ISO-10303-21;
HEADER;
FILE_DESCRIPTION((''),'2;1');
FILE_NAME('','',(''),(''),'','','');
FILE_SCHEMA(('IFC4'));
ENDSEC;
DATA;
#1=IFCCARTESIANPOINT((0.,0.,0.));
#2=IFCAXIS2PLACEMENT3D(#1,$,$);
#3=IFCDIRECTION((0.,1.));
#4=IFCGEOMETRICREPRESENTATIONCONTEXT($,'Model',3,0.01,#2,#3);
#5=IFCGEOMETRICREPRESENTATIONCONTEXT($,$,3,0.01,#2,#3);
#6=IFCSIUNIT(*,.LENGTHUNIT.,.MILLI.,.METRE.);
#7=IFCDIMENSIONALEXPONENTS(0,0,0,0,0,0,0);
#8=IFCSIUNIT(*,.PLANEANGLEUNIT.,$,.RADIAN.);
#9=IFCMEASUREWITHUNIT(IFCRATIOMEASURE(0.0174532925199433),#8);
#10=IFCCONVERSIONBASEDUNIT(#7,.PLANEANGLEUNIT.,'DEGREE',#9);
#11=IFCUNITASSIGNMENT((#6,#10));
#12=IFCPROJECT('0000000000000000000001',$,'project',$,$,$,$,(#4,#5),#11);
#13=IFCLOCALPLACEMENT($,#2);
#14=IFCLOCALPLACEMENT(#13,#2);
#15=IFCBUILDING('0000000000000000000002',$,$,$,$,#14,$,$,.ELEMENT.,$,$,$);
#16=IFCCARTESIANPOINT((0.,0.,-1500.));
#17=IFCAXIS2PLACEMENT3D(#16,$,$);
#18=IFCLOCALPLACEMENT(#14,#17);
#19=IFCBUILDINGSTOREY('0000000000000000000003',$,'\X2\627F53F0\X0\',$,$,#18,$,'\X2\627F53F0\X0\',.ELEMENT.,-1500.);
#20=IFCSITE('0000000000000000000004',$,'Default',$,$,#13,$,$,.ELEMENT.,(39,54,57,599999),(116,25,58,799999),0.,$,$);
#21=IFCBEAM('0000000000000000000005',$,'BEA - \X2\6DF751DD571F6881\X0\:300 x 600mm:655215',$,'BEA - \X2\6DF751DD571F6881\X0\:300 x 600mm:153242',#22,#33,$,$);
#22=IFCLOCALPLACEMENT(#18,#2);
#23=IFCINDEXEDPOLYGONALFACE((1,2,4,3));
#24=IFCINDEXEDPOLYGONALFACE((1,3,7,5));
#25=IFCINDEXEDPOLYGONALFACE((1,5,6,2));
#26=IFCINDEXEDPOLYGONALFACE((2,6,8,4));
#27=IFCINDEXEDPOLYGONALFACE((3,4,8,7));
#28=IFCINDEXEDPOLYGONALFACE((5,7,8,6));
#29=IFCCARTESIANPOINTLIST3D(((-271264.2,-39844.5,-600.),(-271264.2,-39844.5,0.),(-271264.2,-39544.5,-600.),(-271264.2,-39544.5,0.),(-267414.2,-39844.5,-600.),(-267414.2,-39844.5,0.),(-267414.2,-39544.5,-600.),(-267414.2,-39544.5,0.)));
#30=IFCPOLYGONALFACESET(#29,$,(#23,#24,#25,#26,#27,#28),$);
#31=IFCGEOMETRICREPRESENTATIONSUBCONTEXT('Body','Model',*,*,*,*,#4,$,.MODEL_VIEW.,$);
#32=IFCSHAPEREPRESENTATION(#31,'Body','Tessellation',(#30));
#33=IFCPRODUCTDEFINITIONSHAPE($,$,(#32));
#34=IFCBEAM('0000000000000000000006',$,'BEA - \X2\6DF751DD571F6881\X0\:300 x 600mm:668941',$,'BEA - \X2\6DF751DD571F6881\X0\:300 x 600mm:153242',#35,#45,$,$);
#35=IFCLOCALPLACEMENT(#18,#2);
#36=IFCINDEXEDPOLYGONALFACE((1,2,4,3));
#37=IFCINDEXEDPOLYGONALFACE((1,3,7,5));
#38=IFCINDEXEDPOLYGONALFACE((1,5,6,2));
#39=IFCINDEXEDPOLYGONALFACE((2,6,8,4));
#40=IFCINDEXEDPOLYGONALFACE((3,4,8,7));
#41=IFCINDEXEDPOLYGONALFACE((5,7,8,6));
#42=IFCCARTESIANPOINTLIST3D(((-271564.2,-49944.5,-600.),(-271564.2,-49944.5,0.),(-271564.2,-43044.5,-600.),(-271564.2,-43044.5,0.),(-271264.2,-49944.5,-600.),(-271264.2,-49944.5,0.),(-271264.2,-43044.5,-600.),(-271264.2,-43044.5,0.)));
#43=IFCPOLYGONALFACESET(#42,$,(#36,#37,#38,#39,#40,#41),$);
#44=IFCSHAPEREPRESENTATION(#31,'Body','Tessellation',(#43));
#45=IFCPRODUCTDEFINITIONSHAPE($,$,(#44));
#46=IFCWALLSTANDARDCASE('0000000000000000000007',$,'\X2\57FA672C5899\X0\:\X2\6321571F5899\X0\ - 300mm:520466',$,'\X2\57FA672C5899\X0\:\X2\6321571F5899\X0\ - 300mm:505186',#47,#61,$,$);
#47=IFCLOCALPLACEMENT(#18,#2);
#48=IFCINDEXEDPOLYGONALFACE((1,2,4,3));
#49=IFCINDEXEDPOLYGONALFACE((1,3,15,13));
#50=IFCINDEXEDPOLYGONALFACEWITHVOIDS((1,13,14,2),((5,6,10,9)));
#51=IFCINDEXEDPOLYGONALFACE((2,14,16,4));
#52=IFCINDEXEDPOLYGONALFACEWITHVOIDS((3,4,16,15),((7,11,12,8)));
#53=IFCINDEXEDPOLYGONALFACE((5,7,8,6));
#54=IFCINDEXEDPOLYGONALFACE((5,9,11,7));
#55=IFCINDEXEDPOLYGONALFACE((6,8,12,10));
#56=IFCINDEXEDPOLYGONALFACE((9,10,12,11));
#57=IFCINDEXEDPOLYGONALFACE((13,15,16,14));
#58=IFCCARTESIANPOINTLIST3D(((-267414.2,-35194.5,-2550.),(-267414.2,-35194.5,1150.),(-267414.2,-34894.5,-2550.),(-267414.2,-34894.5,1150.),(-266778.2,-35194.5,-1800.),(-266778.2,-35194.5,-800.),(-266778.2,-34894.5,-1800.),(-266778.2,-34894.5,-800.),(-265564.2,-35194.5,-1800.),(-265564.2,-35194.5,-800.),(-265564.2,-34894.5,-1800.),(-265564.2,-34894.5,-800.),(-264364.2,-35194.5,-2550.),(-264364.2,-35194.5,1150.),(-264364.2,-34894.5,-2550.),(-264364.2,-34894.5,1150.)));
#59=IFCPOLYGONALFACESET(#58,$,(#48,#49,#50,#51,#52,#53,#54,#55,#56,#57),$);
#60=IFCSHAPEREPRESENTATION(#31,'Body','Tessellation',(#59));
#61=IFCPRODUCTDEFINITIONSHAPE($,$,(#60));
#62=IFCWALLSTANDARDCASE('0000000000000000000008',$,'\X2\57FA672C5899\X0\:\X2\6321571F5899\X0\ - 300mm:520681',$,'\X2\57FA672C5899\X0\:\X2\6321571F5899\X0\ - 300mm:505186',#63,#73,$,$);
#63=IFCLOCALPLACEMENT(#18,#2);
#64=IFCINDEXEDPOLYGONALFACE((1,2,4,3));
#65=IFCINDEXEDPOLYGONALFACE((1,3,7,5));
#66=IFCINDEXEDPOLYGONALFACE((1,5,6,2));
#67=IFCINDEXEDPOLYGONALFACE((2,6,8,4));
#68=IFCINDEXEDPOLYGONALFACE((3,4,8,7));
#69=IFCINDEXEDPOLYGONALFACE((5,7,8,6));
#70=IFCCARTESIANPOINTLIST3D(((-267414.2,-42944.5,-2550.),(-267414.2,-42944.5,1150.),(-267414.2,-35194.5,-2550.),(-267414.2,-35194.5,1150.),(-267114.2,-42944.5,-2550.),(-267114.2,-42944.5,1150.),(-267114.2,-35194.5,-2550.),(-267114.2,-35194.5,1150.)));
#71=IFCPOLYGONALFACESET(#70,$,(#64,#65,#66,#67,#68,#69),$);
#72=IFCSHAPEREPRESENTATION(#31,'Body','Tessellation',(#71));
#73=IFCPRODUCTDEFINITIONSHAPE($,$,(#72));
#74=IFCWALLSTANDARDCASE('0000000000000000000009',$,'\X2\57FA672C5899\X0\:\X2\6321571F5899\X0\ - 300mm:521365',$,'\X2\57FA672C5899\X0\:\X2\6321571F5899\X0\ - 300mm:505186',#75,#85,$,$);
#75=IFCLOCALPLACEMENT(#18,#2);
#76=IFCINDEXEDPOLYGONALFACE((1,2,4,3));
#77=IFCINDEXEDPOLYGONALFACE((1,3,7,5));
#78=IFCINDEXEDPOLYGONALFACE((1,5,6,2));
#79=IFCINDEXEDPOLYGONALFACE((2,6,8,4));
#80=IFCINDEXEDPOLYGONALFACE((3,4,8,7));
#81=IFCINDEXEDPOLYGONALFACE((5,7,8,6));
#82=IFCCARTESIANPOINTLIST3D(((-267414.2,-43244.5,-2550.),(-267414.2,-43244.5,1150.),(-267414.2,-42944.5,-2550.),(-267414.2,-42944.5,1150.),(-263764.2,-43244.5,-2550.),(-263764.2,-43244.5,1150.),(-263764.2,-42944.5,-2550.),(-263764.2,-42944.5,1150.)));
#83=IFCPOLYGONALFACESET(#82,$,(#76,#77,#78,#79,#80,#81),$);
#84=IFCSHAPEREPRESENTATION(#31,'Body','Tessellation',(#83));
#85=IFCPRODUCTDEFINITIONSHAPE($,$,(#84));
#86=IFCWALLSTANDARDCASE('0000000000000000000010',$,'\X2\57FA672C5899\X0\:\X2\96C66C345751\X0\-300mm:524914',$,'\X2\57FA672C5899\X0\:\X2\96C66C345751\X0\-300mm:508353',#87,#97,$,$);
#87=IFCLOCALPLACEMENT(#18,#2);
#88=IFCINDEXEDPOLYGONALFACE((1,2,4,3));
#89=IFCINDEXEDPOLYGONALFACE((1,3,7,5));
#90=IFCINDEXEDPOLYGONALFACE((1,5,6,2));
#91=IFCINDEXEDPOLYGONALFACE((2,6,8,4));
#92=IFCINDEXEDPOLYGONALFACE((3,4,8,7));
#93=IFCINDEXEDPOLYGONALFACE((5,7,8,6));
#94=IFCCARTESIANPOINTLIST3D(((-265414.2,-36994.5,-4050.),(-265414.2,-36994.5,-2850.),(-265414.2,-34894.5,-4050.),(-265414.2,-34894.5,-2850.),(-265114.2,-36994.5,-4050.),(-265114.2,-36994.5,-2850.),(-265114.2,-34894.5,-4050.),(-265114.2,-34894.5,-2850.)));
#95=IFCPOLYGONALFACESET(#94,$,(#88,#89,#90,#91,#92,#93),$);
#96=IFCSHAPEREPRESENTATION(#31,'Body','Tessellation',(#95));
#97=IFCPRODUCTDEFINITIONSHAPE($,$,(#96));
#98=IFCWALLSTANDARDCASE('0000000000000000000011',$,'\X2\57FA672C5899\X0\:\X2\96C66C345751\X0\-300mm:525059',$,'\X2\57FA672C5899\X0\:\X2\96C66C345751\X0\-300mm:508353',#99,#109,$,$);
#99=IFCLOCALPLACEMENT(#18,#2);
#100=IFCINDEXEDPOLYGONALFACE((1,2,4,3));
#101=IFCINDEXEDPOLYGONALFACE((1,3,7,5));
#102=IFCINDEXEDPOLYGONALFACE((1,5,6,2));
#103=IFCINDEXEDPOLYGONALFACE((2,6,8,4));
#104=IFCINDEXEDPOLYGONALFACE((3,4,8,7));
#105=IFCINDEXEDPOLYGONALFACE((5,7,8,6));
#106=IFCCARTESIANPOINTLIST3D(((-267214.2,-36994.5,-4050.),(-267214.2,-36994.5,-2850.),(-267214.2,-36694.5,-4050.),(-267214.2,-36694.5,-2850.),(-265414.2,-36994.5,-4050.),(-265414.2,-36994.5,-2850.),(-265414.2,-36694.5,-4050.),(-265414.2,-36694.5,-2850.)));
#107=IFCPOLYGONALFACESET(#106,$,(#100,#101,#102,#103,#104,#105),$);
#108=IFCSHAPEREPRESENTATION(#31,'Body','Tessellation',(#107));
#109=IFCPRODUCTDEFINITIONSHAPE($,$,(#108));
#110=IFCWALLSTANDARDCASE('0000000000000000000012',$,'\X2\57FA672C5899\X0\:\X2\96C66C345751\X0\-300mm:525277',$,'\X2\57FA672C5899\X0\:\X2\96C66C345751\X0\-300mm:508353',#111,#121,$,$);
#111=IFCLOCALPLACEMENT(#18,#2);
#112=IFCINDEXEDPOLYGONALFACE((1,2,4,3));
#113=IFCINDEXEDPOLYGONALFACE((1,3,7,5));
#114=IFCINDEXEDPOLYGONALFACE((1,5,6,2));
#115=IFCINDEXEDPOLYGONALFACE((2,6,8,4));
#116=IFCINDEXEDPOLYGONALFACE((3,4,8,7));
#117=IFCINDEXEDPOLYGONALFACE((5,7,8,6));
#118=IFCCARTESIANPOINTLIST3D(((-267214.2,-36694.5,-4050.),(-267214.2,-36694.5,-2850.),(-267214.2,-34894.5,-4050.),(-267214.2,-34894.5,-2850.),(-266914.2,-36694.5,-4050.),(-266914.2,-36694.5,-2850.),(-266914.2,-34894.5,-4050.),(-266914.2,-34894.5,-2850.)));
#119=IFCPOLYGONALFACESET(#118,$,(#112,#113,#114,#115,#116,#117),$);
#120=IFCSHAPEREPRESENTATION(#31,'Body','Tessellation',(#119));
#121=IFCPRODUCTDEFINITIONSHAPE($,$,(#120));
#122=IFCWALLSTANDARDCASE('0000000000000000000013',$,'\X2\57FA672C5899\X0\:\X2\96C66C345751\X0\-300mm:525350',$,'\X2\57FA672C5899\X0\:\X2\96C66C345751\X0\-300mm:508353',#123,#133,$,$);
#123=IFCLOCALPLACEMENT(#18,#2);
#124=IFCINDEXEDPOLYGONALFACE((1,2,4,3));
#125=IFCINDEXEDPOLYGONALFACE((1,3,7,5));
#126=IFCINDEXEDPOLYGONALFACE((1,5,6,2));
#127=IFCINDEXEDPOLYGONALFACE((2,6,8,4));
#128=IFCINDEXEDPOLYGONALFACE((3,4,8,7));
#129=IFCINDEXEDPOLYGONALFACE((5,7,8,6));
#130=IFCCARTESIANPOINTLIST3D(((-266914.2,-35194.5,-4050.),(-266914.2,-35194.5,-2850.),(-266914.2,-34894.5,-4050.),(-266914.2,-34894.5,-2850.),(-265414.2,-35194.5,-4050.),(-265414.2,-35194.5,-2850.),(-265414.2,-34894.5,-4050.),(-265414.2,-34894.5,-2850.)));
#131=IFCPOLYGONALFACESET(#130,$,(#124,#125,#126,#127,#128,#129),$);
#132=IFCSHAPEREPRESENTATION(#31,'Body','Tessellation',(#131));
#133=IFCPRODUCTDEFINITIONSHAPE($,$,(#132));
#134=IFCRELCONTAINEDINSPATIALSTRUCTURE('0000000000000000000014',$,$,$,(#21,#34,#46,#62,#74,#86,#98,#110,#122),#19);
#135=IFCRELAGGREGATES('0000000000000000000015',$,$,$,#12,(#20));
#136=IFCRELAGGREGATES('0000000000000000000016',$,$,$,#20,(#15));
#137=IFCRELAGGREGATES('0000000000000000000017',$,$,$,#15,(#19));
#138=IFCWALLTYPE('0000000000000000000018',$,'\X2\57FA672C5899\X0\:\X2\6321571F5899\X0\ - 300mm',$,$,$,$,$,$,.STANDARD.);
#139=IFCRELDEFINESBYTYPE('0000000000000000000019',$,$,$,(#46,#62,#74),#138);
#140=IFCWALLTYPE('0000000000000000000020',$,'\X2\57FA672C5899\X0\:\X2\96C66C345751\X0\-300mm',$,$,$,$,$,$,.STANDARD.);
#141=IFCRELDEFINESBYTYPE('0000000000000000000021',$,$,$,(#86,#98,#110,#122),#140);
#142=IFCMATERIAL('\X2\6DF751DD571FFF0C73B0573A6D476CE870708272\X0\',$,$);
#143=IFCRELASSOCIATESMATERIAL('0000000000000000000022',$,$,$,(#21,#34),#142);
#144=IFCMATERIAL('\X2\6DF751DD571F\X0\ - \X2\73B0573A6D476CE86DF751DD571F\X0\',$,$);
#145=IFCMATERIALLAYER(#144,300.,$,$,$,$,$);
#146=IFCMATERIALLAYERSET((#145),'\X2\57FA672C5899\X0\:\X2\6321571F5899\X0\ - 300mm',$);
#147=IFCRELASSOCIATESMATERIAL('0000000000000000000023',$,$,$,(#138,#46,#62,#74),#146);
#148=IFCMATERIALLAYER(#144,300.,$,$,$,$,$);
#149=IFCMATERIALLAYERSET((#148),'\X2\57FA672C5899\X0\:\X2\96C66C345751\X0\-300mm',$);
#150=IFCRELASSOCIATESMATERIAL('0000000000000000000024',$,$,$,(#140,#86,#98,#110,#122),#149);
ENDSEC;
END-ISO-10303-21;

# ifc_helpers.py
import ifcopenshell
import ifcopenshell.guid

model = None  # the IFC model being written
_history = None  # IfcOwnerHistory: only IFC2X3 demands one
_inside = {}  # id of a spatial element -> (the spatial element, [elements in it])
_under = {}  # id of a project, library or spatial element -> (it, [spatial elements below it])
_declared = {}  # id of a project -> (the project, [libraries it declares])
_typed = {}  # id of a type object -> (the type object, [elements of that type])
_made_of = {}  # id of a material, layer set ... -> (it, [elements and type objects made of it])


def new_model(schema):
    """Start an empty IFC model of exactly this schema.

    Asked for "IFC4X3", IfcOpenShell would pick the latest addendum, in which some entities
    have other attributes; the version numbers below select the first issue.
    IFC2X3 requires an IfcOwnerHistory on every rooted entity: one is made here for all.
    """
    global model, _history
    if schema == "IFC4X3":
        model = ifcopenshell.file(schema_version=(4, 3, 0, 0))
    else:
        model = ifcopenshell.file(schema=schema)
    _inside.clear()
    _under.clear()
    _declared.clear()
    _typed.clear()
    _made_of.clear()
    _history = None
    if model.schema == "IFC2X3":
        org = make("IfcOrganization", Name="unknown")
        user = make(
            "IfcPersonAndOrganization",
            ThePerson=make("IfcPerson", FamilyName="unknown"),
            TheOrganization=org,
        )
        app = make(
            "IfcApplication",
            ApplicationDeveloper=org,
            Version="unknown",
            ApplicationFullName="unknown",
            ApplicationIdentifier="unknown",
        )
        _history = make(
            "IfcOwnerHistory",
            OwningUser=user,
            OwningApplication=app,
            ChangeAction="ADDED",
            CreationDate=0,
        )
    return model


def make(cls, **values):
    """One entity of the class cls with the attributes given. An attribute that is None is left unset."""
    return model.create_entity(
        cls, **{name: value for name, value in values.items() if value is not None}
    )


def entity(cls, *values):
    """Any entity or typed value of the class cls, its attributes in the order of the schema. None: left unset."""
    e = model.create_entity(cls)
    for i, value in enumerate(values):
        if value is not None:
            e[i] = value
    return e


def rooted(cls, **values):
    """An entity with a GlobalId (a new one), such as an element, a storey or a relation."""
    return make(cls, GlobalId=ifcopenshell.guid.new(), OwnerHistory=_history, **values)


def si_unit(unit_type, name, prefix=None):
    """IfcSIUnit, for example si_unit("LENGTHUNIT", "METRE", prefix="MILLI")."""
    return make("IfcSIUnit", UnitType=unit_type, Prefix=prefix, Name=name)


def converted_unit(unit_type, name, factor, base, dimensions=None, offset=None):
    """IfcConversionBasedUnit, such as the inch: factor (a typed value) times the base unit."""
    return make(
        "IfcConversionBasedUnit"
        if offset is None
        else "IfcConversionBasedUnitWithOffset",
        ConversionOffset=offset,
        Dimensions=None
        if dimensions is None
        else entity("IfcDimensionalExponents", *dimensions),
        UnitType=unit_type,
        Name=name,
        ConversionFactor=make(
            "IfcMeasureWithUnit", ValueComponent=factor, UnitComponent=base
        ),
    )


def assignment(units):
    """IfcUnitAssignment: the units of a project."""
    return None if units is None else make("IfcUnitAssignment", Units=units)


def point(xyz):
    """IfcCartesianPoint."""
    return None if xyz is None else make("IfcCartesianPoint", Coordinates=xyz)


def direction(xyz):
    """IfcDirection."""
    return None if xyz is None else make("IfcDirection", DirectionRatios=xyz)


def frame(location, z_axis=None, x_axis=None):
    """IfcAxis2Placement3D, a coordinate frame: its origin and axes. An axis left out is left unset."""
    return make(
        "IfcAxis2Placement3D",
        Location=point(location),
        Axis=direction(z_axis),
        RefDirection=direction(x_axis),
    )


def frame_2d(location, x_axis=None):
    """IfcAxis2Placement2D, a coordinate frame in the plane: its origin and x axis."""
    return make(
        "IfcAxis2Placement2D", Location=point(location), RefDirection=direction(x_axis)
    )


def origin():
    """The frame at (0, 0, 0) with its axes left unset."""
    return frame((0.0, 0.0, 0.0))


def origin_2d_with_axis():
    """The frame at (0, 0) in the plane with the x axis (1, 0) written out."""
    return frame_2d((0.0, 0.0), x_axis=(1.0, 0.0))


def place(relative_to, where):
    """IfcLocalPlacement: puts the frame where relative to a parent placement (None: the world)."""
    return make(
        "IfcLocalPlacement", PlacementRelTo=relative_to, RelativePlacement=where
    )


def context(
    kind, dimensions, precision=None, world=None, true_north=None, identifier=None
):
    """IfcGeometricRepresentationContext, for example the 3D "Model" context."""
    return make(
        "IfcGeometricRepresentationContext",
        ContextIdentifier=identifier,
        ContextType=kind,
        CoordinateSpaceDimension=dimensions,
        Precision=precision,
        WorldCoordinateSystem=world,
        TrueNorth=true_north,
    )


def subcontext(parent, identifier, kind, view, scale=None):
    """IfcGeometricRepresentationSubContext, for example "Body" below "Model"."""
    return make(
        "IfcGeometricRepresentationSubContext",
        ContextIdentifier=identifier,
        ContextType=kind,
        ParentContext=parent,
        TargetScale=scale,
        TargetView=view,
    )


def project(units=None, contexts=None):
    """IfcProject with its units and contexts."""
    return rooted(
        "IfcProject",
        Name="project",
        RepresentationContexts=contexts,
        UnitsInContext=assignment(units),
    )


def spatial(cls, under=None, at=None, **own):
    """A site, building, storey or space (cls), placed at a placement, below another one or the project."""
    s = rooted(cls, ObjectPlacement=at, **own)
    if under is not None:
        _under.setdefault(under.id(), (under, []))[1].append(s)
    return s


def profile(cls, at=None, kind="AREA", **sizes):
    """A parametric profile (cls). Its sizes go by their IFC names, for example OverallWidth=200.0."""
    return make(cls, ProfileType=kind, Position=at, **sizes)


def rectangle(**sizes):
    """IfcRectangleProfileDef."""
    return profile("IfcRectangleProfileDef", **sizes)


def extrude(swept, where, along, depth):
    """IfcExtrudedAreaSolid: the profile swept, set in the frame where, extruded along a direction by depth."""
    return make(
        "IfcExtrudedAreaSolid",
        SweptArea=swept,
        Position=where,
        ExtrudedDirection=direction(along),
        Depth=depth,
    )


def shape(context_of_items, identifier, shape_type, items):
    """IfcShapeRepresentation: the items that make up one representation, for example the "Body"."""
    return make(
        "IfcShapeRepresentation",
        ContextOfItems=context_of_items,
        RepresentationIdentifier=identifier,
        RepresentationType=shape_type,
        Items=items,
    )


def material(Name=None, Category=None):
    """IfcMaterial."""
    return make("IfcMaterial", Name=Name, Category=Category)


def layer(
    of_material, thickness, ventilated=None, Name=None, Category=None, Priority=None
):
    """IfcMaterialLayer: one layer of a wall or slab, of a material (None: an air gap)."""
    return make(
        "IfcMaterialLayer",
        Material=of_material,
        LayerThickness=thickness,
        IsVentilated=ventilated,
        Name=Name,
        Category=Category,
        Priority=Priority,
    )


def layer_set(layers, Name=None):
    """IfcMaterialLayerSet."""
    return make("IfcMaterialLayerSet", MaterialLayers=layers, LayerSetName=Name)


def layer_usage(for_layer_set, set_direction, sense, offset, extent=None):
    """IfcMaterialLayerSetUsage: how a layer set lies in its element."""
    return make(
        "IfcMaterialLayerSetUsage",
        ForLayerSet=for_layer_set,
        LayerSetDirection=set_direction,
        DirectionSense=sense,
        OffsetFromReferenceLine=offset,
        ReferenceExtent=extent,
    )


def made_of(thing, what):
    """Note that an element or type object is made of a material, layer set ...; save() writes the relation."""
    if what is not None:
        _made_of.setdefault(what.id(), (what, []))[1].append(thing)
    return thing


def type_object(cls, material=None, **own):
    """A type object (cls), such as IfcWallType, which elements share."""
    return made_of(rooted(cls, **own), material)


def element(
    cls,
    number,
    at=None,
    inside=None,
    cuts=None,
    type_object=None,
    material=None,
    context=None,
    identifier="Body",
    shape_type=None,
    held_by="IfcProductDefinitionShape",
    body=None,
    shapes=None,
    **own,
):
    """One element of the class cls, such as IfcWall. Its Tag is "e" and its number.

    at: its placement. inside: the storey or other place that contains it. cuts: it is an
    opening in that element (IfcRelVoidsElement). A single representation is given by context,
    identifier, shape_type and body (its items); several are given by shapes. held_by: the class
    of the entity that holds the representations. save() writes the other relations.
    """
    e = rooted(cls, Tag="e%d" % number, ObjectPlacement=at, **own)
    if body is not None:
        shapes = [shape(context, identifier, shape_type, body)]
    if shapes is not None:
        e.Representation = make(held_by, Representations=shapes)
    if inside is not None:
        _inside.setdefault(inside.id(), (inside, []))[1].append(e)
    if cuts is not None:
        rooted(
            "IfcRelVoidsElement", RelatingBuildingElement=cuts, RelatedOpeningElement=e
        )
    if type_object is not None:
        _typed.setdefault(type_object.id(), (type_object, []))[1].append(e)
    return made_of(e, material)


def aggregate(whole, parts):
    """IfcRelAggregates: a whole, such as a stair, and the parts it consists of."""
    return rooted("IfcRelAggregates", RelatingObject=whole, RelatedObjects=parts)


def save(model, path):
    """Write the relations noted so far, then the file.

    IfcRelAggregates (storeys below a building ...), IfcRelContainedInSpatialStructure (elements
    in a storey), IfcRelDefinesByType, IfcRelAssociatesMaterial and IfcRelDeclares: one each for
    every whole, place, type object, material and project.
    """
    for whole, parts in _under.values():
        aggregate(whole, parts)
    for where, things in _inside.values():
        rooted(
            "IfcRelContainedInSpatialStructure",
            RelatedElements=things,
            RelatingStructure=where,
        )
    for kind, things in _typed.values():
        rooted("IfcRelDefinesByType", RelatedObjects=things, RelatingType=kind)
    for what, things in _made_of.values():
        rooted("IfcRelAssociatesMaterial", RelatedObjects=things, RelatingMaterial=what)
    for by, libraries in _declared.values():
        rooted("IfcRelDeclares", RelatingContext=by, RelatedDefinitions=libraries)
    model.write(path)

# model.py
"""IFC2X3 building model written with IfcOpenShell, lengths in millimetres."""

from ifc_helpers import new_model, entity, si_unit, converted_unit, direction, frame, frame_2d, origin, origin_2d_with_axis, place, context, subcontext, project, spatial, rectangle, extrude, material, layer, layer_set, layer_usage, type_object, element, save


model = new_model("IFC2X3")

# Units and contexts
model_context = context("Model", 3, precision=0.01, world=origin(), true_north=direction((0.0, 1.0)))
context_of_model = context(None, 3, precision=0.01, world=origin(), true_north=direction((0.0, 1.0)))
body_context = subcontext(model_context, "Body", "Model", "MODEL_VIEW")
ifc_project = project(units=[si_unit("LENGTHUNIT", "METRE", prefix="MILLI"), converted_unit("PLANEANGLEUNIT", "DEGREE", entity("IfcRatioMeasure", 0.0174532925199433), si_unit("PLANEANGLEUNIT", "RADIAN"), dimensions=[0, 0, 0, 0, 0, 0, 0])], contexts=[model_context, context_of_model])

# Site, building, storey
site_placement = place(None, origin())
site = spatial("IfcSite", under=ifc_project, at=site_placement, Name="Default", CompositionType="ELEMENT", RefLatitude=(39, 54, 57, 599999), RefLongitude=(116, 25, 58, 799999), RefElevation=0.0)
building_placement = place(site_placement, origin())
building = spatial("IfcBuilding", under=site, at=building_placement, CompositionType="ELEMENT")
storey_placement = place(building_placement, frame((0.0, 0.0, -1500.0)))
storey = spatial("IfcBuildingStorey", under=building, at=storey_placement, Name="承台", LongName="承台", CompositionType="ELEMENT", Elevation=-1500.0)

# Shared definitions
ifc_material_1 = material(Name="混凝土 - 现场浇注混凝土")

# Shared definitions
ifc_material_2 = material(Name="混凝土，现场浇注灰色")

# Beams
beam_1_placement = place(storey_placement, frame((-271414.2, -39694.5, 0.0)))
element("IfcBeam", 1, at=beam_1_placement, inside=storey, material=ifc_material_2, Name="BEA - 混凝土梁:300 x 600mm:655215", ObjectType="BEA - 混凝土梁:300 x 600mm:153242", context=body_context, shape_type="SweptSolid", body=[
    extrude(rectangle(XDim=600.0, YDim=300.0, at=frame_2d((0.0, 0.0), x_axis=(1.0, 0.0))), frame((150.0, 0.0, -300.0), z_axis=(1.0, 0.0, 0.0), x_axis=(0.0, 0.0, -1.0)), (0.0, 0.0, 1.0), 3850.0),
])
beam_2_placement = place(storey_placement, frame((-271414.2, -43044.5, 0.0), z_axis=(0.0, 0.0, 1.0), x_axis=(0.0, -1.0, 0.0)))
element("IfcBeam", 2, at=beam_2_placement, inside=storey, material=ifc_material_2, Name="BEA - 混凝土梁:300 x 600mm:668941", ObjectType="BEA - 混凝土梁:300 x 600mm:153242", context=body_context, shape_type="SweptSolid", body=[
    extrude(rectangle(XDim=600.0, YDim=300.0, at=origin_2d_with_axis()), frame((0.0, 0.0, -300.0), z_axis=(1.0, 0.0, 0.0), x_axis=(0.0, 0.0, -1.0)), (0.0, 0.0, 1.0), 6900.0),
])

# Wall, opening
ifc_layer_1 = layer(ifc_material_1, 300.0)
ifc_layer_set_1 = layer_set([ifc_layer_1], Name="基本墙:挡土墙 - 300mm")
ifc_layer_usage_1 = layer_usage(ifc_layer_set_1, "AXIS2", "NEGATIVE", 150.0)
wall_type_1 = type_object("IfcWallType", Name="基本墙:挡土墙 - 300mm", PredefinedType="STANDARD", material=ifc_layer_set_1)
wall_1_placement = place(storey_placement, frame((-264364.2, -35044.5, -2550.0), z_axis=(0.0, 0.0, 1.0), x_axis=(-1.0, 0.0, 0.0)))
wall_1 = element("IfcWallStandardCase", 3, at=wall_1_placement, inside=storey, type_object=wall_type_1, material=ifc_layer_usage_1, Name="基本墙:挡土墙 - 300mm:520466", ObjectType="基本墙:挡土墙 - 300mm:505186", context=body_context, shape_type="SweptSolid", body=[
    extrude(rectangle(XDim=3050.0, YDim=300.0, at=frame_2d((1525.0, 0.0), x_axis=(-1.0, 0.0))), origin(), (0.0, 0.0, 1.0), 3700.0),
])
opening_1_placement = place(wall_1_placement, frame((2414.0, 150.0, 750.0)))
element("IfcOpeningElement", 4, at=opening_1_placement, cuts=wall_1, ObjectType="Opening", context=body_context, shape_type="SweptSolid", body=[
    extrude(rectangle(XDim=1000.0, YDim=1214.0, at=frame_2d((0.0, 0.0), x_axis=(1.0, 0.0))), frame((-607.0, -300.0, 500.0), z_axis=(0.0, 1.0, 0.0), x_axis=(0.0, 0.0, -1.0)), (0.0, 0.0, 1.0), 300.0),
])

# Walls
ifc_layer_usage_2 = layer_usage(ifc_layer_set_1, "AXIS2", "NEGATIVE", 150.0)
wall_2_placement = place(storey_placement, frame((-267264.2, -35194.5, -2550.0), z_axis=(0.0, 0.0, 1.0), x_axis=(0.0, -1.0, 0.0)))
element("IfcWallStandardCase", 5, at=wall_2_placement, inside=storey, type_object=wall_type_1, material=ifc_layer_usage_2, Name="基本墙:挡土墙 - 300mm:520681", ObjectType="基本墙:挡土墙 - 300mm:505186", context=body_context, shape_type="SweptSolid", body=[
    extrude(rectangle(XDim=7750.0, YDim=300.0, at=frame_2d((3875.0, 0.0), x_axis=(-1.0, 0.0))), origin(), (0.0, 0.0, 1.0), 3700.0),
])
ifc_layer_usage_3 = layer_usage(ifc_layer_set_1, "AXIS2", "NEGATIVE", 150.0)
wall_3_placement = place(storey_placement, frame((-267414.2, -43094.5, -2550.0)))
element("IfcWallStandardCase", 6, at=wall_3_placement, inside=storey, type_object=wall_type_1, material=ifc_layer_usage_3, Name="基本墙:挡土墙 - 300mm:521365", ObjectType="基本墙:挡土墙 - 300mm:505186", context=body_context, shape_type="SweptSolid", body=[
    extrude(rectangle(XDim=3650.0, YDim=300.0, at=frame_2d((1825.0, 0.0), x_axis=(-1.0, 0.0))), origin(), (0.0, 0.0, 1.0), 3700.0),
])
ifc_layer_2 = layer(ifc_material_1, 300.0)
ifc_layer_set_2 = layer_set([ifc_layer_2], Name="基本墙:集水坑-300mm")
ifc_layer_usage_4 = layer_usage(ifc_layer_set_2, "AXIS2", "NEGATIVE", 150.0)
wall_type_2 = type_object("IfcWallType", Name="基本墙:集水坑-300mm", PredefinedType="STANDARD", material=ifc_layer_set_2)
wall_4_placement = place(storey_placement, frame((-265264.2, -34894.5, -4050.0), z_axis=(0.0, 0.0, 1.0), x_axis=(0.0, -1.0, 0.0)))
element("IfcWallStandardCase", 7, at=wall_4_placement, inside=storey, type_object=wall_type_2, material=ifc_layer_usage_4, Name="基本墙:集水坑-300mm:524914", ObjectType="基本墙:集水坑-300mm:508353", context=body_context, shape_type="SweptSolid", body=[
    extrude(rectangle(XDim=2100.0, YDim=300.0, at=frame_2d((1050.0, 0.0), x_axis=(-1.0, 0.0))), origin(), (0.0, 0.0, 1.0), 1200.0),
])
ifc_layer_usage_5 = layer_usage(ifc_layer_set_2, "AXIS2", "NEGATIVE", 150.0)
wall_5_placement = place(storey_placement, frame((-267214.2, -36844.5, -4050.0)))
element("IfcWallStandardCase", 8, at=wall_5_placement, inside=storey, type_object=wall_type_2, material=ifc_layer_usage_5, Name="基本墙:集水坑-300mm:525059", ObjectType="基本墙:集水坑-300mm:508353", context=body_context, shape_type="SweptSolid", body=[
    extrude(rectangle(XDim=1800.0, YDim=300.0, at=frame_2d((900.0, 0.0), x_axis=(-1.0, 0.0))), origin(), (0.0, 0.0, 1.0), 1200.0),
])
ifc_layer_usage_6 = layer_usage(ifc_layer_set_2, "AXIS2", "NEGATIVE", 150.0)
wall_6_placement = place(storey_placement, frame((-267064.2, -34894.5, -4050.0), z_axis=(0.0, 0.0, 1.0), x_axis=(0.0, -1.0, 0.0)))
element("IfcWallStandardCase", 9, at=wall_6_placement, inside=storey, type_object=wall_type_2, material=ifc_layer_usage_6, Name="基本墙:集水坑-300mm:525277", ObjectType="基本墙:集水坑-300mm:508353", context=body_context, shape_type="SweptSolid", body=[
    extrude(rectangle(XDim=1800.0, YDim=300.0, at=frame_2d((900.0, 0.0), x_axis=(-1.0, 0.0))), origin(), (0.0, 0.0, 1.0), 1200.0),
])
ifc_layer_usage_7 = layer_usage(ifc_layer_set_2, "AXIS2", "NEGATIVE", 150.0)
wall_7_placement = place(storey_placement, frame((-266914.2, -35044.5, -4050.0)))
element("IfcWallStandardCase", 10, at=wall_7_placement, inside=storey, type_object=wall_type_2, material=ifc_layer_usage_7, Name="基本墙:集水坑-300mm:525350", ObjectType="基本墙:集水坑-300mm:508353", context=body_context, shape_type="SweptSolid", body=[
    extrude(rectangle(XDim=1500.0, YDim=300.0, at=frame_2d((750.0, 0.0), x_axis=(-1.0, 0.0))), origin(), (0.0, 0.0, 1.0), 1200.0),
])

save(model, "model.ifc")
